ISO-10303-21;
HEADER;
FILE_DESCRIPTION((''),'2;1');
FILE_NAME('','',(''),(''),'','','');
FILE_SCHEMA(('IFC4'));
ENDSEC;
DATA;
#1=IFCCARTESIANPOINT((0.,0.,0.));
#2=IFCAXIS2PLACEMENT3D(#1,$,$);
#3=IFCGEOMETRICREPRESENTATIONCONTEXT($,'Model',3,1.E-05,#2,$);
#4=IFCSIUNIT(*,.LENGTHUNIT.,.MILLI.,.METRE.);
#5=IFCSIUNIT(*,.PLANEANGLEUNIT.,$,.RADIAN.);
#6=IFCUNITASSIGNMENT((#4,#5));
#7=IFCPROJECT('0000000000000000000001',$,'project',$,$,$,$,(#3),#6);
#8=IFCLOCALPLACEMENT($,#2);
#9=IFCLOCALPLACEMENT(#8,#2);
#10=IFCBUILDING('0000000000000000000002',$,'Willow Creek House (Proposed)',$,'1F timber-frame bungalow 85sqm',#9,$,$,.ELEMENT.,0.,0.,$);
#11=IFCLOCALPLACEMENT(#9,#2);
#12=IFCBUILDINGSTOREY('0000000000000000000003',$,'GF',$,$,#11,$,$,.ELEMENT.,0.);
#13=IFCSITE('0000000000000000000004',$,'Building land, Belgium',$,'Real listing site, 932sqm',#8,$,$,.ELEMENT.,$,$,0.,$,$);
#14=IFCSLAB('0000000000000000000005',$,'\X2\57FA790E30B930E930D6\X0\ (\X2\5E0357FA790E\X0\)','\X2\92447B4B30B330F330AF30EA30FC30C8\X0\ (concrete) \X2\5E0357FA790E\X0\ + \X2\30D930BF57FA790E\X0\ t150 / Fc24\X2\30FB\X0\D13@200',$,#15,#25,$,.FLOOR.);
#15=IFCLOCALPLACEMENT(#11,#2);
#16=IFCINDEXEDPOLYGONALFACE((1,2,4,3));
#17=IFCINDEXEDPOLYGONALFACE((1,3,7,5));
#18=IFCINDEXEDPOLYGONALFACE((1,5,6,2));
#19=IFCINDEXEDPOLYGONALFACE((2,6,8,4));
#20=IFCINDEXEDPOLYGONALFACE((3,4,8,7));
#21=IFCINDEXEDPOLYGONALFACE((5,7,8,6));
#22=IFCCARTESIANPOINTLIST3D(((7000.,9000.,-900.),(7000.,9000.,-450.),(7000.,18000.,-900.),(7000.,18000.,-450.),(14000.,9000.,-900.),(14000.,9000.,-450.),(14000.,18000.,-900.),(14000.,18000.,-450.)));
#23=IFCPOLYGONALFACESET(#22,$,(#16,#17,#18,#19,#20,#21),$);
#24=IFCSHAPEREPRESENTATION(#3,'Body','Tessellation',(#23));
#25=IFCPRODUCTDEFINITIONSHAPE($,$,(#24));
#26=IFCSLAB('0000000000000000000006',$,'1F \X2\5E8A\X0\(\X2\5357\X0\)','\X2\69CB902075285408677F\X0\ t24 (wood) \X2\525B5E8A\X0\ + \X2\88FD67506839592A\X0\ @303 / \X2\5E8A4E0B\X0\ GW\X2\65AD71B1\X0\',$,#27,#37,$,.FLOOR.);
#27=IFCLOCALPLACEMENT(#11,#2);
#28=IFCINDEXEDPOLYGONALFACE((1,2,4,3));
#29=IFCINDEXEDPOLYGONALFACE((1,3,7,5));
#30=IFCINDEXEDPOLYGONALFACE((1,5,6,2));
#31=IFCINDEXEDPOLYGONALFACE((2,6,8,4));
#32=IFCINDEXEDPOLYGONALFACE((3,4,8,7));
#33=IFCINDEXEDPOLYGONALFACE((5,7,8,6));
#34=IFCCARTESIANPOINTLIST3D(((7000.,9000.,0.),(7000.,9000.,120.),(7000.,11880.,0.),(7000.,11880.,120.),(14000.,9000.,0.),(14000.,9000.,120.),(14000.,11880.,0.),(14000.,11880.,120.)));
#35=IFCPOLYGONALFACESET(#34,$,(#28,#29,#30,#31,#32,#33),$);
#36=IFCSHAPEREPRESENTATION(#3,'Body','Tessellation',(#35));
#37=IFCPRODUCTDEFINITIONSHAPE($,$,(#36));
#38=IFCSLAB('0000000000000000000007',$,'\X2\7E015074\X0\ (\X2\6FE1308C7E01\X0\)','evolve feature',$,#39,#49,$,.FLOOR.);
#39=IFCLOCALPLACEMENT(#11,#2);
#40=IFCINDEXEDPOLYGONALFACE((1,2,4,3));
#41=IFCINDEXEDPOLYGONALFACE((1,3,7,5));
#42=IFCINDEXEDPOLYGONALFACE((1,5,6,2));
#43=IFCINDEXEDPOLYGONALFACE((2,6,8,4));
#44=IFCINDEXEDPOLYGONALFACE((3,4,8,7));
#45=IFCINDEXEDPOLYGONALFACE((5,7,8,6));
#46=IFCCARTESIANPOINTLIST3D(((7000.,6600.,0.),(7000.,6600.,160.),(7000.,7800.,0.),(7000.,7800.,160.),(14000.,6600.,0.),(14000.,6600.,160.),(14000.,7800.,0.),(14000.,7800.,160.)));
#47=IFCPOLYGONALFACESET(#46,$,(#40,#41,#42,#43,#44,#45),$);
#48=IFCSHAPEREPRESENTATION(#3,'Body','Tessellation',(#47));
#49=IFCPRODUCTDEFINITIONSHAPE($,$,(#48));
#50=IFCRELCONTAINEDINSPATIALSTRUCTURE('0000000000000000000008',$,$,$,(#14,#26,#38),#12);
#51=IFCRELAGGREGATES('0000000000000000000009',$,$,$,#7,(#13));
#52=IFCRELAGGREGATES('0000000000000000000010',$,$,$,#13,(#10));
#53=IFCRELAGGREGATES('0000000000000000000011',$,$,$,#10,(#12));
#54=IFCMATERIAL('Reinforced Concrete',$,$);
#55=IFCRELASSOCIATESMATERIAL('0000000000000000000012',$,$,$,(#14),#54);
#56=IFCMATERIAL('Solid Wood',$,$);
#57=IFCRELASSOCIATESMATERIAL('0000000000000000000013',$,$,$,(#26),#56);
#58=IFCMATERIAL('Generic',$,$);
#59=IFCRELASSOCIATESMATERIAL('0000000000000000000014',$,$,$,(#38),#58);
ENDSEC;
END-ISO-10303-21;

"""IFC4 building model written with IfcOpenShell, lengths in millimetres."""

from ifc_helpers import new_model, si_unit, frame, frame_2d, origin, place, context, project, spatial, rectangle, extrude, material, element, save


model = new_model("IFC4")

# Units and contexts
model_context = context("Model", 3, precision=1e-05, world=origin())
ifc_project = project(units=[si_unit("LENGTHUNIT", "METRE", prefix="MILLI"), si_unit("PLANEANGLEUNIT", "RADIAN")], contexts=[model_context])

# Site, building, storey
site_placement = place(None, origin())
site = spatial("IfcSite", under=ifc_project, at=site_placement, Name="Building land, Belgium", ObjectType="Real listing site, 932sqm", CompositionType="ELEMENT", RefElevation=0.0)
building_placement = place(site_placement, origin())
building = spatial("IfcBuilding", under=site, at=building_placement, Name="Willow Creek House (Proposed)", ObjectType="1F timber-frame bungalow 85sqm", CompositionType="ELEMENT", ElevationOfRefHeight=0.0, ElevationOfTerrain=0.0)
storey_placement = place(building_placement, origin())
storey = spatial("IfcBuildingStorey", under=building, at=storey_placement, Name="GF", CompositionType="ELEMENT", Elevation=0.0)

# Slabs
ifc_material_1 = material(Name="Reinforced Concrete")
slab_1_placement = place(storey_placement, frame((3500.0, 4500.0, -450.0)))
element("IfcSlab", 1, at=slab_1_placement, inside=storey, material=ifc_material_1, Name="基礎スラブ (布基礎)", Description="鉄筋コンクリート (concrete) 布基礎 + ベタ基礎 t150 / Fc24・D13@200", PredefinedType="FLOOR", context=model_context, shape_type="SweptSolid", body=[
    extrude(rectangle(XDim=7000.0, YDim=9000.0, at=frame_2d((3500.0, 4500.0))), frame((3500.0, 4500.0, -450.0)), (0.0, 0.0, 1.0), 450.0),
])
ifc_material_2 = material(Name="Solid Wood")
slab_2_placement = place(storey_placement, frame((3500.0, 4500.0, 0.0)))
element("IfcSlab", 2, at=slab_2_placement, inside=storey, material=ifc_material_2, Name="1F 床(南)", Description="構造用合板 t24 (wood) 剛床 + 製材根太 @303 / 床下 GW断熱", PredefinedType="FLOOR", context=model_context, shape_type="SweptSolid", body=[
    extrude(rectangle(XDim=7000.0, YDim=2880.0, at=frame_2d((3500.0, 1440.0))), frame((3500.0, 4500.0, 0.0)), (0.0, 0.0, 1.0), 120.0),
])
ifc_material_3 = material(Name="Generic")
slab_3_placement = place(storey_placement, frame((3500.0, 3300.0, 0.0)))
element("IfcSlab", 3, at=slab_3_placement, inside=storey, material=ifc_material_3, Name="縁側 (濡れ縁)", Description="evolve feature", PredefinedType="FLOOR", context=model_context, shape_type="SweptSolid", body=[
    extrude(rectangle(XDim=7000.0, YDim=1200.0, at=frame_2d((3500.0, 600.0))), frame((3500.0, 3300.0, 0.0)), (0.0, 0.0, 1.0), 160.0),
])

save(model, "model.ifc")
